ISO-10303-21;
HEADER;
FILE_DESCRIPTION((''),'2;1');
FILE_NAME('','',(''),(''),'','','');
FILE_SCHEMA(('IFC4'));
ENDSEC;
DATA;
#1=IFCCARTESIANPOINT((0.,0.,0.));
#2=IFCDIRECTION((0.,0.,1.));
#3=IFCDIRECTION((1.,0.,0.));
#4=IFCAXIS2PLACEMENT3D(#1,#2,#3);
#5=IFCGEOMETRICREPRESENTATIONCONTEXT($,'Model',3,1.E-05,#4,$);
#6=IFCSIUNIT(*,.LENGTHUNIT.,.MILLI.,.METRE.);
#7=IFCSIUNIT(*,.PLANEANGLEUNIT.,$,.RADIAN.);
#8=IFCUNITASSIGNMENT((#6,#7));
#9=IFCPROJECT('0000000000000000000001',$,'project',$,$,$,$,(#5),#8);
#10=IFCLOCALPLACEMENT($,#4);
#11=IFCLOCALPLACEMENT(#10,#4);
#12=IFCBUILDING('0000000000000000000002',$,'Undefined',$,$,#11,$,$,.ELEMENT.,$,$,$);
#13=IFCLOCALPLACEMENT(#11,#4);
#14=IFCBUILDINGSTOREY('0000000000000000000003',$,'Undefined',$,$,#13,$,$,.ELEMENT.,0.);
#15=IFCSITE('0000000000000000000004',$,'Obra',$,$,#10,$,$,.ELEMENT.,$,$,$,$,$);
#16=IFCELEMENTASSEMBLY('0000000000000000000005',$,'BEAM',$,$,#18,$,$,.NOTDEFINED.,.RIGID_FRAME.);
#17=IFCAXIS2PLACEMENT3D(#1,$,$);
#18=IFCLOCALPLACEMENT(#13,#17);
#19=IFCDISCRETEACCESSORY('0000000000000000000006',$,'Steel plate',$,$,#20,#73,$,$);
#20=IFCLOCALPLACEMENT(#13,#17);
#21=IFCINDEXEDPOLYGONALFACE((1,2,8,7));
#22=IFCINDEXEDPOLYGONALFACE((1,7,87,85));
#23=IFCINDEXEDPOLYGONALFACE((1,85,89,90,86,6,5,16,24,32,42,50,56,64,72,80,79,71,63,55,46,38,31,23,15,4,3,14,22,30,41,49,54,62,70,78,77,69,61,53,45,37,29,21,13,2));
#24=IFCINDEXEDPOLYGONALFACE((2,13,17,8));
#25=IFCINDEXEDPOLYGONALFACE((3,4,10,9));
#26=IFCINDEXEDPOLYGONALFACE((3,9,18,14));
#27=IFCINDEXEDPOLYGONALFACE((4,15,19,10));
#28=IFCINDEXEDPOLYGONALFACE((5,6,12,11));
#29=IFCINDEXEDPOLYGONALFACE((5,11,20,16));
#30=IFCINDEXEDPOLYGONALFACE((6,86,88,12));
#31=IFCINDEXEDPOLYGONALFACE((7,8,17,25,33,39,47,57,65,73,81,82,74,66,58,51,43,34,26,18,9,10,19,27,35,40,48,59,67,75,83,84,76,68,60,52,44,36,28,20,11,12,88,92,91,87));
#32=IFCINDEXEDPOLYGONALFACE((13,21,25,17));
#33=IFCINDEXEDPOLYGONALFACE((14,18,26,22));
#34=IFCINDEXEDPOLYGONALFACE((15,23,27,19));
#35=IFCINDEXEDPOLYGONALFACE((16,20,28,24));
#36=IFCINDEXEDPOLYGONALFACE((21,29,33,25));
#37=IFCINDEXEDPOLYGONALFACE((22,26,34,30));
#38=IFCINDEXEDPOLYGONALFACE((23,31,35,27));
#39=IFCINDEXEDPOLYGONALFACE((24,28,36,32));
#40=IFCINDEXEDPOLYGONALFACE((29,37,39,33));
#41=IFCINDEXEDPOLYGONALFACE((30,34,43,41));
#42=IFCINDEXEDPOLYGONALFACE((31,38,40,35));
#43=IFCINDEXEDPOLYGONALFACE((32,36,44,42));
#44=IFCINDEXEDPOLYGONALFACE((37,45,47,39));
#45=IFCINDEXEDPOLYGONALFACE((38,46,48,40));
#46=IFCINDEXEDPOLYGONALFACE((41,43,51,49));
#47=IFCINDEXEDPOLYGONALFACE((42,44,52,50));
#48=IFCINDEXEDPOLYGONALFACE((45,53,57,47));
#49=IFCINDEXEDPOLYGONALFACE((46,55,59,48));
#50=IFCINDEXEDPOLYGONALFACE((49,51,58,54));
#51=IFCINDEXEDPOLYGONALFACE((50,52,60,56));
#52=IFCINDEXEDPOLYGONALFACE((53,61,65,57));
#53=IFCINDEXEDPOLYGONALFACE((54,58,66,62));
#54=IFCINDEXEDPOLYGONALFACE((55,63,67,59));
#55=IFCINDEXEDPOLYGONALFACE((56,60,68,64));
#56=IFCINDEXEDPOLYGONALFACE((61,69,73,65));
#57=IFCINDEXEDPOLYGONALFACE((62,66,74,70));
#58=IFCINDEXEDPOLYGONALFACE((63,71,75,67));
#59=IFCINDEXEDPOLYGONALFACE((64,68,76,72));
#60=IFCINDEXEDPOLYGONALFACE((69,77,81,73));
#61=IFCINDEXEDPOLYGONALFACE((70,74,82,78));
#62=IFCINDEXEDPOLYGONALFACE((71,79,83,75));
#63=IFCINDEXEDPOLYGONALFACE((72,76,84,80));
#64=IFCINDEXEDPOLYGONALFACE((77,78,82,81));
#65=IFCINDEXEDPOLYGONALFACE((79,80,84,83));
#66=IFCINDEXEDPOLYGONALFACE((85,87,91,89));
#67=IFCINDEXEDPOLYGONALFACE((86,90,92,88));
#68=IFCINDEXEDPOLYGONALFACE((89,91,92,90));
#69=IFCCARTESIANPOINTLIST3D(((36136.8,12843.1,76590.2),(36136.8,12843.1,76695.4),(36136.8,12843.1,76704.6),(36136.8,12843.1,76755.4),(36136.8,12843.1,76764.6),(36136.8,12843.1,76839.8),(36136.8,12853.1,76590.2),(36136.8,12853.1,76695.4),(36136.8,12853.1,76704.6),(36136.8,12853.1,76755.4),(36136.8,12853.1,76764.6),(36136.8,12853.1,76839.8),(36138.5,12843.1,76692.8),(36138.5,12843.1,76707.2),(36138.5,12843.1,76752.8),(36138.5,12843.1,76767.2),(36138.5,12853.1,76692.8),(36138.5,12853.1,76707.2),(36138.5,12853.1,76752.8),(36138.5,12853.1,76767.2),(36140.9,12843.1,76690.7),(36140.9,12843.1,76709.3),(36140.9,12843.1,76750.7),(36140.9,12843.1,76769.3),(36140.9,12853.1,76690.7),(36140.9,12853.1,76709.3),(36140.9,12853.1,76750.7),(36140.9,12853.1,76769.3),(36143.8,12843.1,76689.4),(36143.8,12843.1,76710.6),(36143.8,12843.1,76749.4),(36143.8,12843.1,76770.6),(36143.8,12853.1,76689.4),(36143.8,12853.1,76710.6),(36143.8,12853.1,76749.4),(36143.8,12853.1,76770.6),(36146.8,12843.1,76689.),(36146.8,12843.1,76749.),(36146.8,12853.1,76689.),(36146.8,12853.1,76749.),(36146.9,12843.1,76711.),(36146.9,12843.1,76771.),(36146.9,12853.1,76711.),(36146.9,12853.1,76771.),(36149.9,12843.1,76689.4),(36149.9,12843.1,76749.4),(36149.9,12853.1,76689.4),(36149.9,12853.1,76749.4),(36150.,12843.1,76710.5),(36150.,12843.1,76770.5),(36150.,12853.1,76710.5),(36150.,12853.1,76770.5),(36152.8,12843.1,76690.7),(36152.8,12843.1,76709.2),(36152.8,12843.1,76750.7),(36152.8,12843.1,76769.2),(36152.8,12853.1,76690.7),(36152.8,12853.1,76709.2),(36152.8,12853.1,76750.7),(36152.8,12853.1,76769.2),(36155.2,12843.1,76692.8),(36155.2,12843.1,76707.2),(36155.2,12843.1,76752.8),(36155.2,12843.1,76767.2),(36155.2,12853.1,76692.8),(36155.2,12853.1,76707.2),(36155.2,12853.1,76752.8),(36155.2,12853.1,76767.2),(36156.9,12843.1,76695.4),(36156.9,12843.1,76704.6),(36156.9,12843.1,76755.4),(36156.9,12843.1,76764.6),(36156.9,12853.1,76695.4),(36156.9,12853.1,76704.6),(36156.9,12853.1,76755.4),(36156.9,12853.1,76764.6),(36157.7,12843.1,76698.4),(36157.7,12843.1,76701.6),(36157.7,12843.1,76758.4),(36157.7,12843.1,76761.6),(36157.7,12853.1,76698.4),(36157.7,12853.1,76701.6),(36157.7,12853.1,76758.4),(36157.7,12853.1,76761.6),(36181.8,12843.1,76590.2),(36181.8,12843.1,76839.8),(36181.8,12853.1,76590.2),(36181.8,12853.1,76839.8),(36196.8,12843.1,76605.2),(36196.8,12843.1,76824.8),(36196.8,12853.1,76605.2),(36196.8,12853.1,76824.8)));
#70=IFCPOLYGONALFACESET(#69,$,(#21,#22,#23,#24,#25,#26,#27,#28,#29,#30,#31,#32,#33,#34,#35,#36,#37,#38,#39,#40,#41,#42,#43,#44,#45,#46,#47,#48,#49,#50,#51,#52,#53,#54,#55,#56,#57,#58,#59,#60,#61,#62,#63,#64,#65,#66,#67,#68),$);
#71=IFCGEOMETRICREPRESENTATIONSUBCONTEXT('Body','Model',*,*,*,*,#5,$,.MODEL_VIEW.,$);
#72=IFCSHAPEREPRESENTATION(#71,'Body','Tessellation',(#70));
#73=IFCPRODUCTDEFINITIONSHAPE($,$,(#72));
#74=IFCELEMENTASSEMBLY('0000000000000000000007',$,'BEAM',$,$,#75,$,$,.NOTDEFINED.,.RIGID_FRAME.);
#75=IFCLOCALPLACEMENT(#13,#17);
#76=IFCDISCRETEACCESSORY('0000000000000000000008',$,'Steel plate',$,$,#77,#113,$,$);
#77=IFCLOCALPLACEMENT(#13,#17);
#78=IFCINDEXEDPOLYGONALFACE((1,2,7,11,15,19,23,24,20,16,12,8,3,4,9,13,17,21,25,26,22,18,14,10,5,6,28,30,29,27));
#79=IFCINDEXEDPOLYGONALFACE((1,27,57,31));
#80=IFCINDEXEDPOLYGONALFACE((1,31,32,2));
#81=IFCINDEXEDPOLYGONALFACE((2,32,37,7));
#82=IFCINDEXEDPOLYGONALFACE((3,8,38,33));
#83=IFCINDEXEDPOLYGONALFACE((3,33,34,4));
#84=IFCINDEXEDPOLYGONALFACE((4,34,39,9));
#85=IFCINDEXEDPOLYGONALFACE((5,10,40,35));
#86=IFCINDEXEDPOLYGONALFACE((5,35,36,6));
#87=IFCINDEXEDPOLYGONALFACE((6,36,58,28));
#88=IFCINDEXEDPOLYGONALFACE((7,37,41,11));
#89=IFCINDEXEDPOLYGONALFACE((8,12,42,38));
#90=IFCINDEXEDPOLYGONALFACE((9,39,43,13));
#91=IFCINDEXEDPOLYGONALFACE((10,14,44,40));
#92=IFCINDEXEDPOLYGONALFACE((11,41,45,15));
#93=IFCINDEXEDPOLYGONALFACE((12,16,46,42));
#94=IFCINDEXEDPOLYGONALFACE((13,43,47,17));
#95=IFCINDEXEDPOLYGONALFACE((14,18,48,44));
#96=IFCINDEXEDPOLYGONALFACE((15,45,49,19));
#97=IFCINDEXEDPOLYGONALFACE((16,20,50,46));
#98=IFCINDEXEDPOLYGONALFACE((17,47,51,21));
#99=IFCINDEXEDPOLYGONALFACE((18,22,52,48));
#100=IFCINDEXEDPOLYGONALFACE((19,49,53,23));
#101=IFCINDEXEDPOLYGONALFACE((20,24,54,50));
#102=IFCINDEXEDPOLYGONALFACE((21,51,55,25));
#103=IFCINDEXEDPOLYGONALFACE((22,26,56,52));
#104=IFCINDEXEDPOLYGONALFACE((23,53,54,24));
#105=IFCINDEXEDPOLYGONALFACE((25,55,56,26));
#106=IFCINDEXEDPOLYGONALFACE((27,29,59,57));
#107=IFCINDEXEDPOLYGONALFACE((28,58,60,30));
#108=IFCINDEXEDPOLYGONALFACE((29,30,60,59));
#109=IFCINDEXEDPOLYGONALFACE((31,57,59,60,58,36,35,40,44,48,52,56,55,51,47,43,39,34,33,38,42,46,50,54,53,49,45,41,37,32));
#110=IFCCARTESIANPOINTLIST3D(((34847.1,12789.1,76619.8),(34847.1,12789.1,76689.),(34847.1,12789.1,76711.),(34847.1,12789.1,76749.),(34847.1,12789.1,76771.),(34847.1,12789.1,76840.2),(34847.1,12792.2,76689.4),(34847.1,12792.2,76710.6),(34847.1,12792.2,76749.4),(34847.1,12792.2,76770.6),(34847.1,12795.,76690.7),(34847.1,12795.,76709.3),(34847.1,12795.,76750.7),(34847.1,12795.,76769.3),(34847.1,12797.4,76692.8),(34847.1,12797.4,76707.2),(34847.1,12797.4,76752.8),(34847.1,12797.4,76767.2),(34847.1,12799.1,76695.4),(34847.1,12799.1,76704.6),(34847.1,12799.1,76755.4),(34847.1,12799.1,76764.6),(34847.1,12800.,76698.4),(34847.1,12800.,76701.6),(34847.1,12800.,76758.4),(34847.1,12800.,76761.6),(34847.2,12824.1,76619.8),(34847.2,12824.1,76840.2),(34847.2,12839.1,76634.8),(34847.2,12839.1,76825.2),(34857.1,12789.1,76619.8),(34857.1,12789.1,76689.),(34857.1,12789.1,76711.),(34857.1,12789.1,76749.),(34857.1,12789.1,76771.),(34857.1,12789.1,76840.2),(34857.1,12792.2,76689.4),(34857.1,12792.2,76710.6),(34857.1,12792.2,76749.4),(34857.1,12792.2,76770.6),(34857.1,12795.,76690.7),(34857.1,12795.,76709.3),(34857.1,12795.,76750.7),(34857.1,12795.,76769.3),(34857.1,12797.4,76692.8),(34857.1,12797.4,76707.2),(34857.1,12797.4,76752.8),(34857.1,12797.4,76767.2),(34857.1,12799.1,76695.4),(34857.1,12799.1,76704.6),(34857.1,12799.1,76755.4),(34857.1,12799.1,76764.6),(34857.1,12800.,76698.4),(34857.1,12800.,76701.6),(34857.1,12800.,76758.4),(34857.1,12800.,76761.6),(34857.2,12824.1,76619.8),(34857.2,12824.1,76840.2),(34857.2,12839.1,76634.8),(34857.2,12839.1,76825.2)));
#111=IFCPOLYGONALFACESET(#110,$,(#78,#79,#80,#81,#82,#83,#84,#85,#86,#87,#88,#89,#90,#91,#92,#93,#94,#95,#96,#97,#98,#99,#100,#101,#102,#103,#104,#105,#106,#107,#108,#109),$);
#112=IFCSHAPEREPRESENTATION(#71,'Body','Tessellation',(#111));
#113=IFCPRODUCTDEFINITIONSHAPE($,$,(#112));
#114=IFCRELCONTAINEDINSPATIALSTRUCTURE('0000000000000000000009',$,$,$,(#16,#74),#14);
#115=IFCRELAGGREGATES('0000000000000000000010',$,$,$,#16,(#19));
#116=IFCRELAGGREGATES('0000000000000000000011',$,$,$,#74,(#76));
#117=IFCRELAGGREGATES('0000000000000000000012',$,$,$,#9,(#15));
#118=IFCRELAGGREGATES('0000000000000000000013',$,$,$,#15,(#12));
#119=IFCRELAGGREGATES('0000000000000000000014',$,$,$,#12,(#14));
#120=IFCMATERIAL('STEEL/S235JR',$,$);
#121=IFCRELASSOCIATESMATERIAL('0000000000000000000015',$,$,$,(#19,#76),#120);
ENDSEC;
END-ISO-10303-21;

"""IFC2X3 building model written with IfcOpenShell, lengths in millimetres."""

from ifc_helpers import new_model, si_unit, frame, origin_with_axes, origin_2d_with_axis, place, context, subcontext, project, spatial, polyline, circle, outline, extrude, source, transform, mapped, material, element, aggregate, save


model = new_model("IFC2X3")

# Units and contexts
model_context = context("Model", 3, precision=1e-05, world=origin_with_axes())
body_context = subcontext(model_context, "Body", "Model", "MODEL_VIEW")
ifc_project = project(units=[si_unit("LENGTHUNIT", "METRE", prefix="MILLI"), si_unit("PLANEANGLEUNIT", "RADIAN")], contexts=[model_context])

# Site, building, storey
site_placement = place(None, origin_with_axes())
site = spatial("IfcSite", under=ifc_project, at=site_placement, Name="Obra", CompositionType="ELEMENT")
building_placement = place(site_placement, origin_with_axes())
building = spatial("IfcBuilding", under=site, at=building_placement, Name="Undefined", CompositionType="ELEMENT")
storey_placement = place(building_placement, origin_with_axes())
storey = spatial("IfcBuildingStorey", under=building, at=storey_placement, Name="Undefined", CompositionType="ELEMENT", Elevation=0.0)

# Shared definitions
ifc_material = material(Name="STEEL/S235JR")

# Element assembly
assembly_1_placement = place(storey_placement, origin_with_axes())
assembly_1 = element("IfcElementAssembly", 1, at=assembly_1_placement, inside=storey, Name="BEAM", AssemblyPlace="NOTDEFINED", PredefinedType="RIGID_FRAME")
shared_shape_1 = source(origin_with_axes(), body_context, "Body", "SweptSolid", [
    extrude(circle(Radius=11.0, at=origin_2d_with_axis()), frame((0.0, -13.2, 0.0), z_axis=(0.0, 1.0, 0.0), x_axis=(1.0, 0.0, 0.0)), (0.0, 0.0, 1.0), 10.2),
])

# Discrete accessory, opening
discrete_accessory_1_placement = place(assembly_1_placement, frame((36136.8, 12848.1, 76590.2), z_axis=(0.0, -1.0, 0.0), x_axis=(1.0, 0.0, 0.0)))
discrete_accessory_1 = element("IfcDiscreteAccessory", 2, at=discrete_accessory_1_placement, material=ifc_material, Name="Steel plate", context=body_context, shape_type="SweptSolid", body=[
    extrude(outline(polyline([(0.0, 0.0), (45.0, 0.0), (60.0, 15.0), (60.0, 234.6), (45.0, 249.6), (0.0, 249.6), (0.0, 0.0)])), frame((0.0, 0.0, -5.0), z_axis=(0.0, 0.0, 1.0), x_axis=(1.0, 0.0, 0.0)), (0.0, 0.0, 1.0), 10.0),
])
opening_1_placement = place(assembly_1_placement, frame((36186.8, 12840.0, 76850.0), z_axis=(-1.0, 0.0, 0.0), x_axis=(0.0, 0.0, -1.0)))
element("IfcOpeningElement", 3, at=opening_1_placement, cuts=discrete_accessory_1, ObjectType="Opening", context=body_context, shape_type="MappedRepresentation", body=[
    mapped(shared_shape_1, transform((90.0, 0.0, 40.0))),
    mapped(shared_shape_1, transform((150.0, 0.0, 40.0))),
])
aggregate(assembly_1, [discrete_accessory_1])

# Element assembly, discrete accessory, opening
assembly_2_placement = place(storey_placement, origin_with_axes())
assembly_2 = element("IfcElementAssembly", 4, at=assembly_2_placement, inside=storey, Name="BEAM", AssemblyPlace="NOTDEFINED", PredefinedType="RIGID_FRAME")
discrete_accessory_2_placement = place(assembly_2_placement, frame((34852.1, 12789.1, 76619.8), z_axis=(0.999999, -0.001625, 0.0), x_axis=(0.001625, 0.999999, 0.0)))
discrete_accessory_2 = element("IfcDiscreteAccessory", 5, at=discrete_accessory_2_placement, material=ifc_material, Name="Steel plate", context=body_context, shape_type="SweptSolid", body=[
    extrude(outline(polyline([(0.0, 0.0), (35.0, 0.0), (50.0, 15.0), (50.0, 205.4), (35.0, 220.4), (0.0, 220.4), (0.0, 0.0)])), frame((0.0, 0.0, -5.0), z_axis=(0.0, 0.0, 1.0), x_axis=(1.0, 0.0, 0.0)), (0.0, 0.0, 1.0), 10.0),
])
opening_2_placement = place(assembly_2_placement, frame((34860.3, 12829.1, 76850.0), z_axis=(-0.001625, -0.999999, 0.0), x_axis=(0.0, 0.0, -1.0)))
element("IfcOpeningElement", 6, at=opening_2_placement, cuts=discrete_accessory_2, ObjectType="Opening", context=body_context, shape_type="MappedRepresentation", body=[
    mapped(shared_shape_1, transform((90.0, 0.0, 40.0))),
    mapped(shared_shape_1, transform((150.0, 0.0, 40.0))),
])
aggregate(assembly_2, [discrete_accessory_2])

save(model, "model.ifc")
